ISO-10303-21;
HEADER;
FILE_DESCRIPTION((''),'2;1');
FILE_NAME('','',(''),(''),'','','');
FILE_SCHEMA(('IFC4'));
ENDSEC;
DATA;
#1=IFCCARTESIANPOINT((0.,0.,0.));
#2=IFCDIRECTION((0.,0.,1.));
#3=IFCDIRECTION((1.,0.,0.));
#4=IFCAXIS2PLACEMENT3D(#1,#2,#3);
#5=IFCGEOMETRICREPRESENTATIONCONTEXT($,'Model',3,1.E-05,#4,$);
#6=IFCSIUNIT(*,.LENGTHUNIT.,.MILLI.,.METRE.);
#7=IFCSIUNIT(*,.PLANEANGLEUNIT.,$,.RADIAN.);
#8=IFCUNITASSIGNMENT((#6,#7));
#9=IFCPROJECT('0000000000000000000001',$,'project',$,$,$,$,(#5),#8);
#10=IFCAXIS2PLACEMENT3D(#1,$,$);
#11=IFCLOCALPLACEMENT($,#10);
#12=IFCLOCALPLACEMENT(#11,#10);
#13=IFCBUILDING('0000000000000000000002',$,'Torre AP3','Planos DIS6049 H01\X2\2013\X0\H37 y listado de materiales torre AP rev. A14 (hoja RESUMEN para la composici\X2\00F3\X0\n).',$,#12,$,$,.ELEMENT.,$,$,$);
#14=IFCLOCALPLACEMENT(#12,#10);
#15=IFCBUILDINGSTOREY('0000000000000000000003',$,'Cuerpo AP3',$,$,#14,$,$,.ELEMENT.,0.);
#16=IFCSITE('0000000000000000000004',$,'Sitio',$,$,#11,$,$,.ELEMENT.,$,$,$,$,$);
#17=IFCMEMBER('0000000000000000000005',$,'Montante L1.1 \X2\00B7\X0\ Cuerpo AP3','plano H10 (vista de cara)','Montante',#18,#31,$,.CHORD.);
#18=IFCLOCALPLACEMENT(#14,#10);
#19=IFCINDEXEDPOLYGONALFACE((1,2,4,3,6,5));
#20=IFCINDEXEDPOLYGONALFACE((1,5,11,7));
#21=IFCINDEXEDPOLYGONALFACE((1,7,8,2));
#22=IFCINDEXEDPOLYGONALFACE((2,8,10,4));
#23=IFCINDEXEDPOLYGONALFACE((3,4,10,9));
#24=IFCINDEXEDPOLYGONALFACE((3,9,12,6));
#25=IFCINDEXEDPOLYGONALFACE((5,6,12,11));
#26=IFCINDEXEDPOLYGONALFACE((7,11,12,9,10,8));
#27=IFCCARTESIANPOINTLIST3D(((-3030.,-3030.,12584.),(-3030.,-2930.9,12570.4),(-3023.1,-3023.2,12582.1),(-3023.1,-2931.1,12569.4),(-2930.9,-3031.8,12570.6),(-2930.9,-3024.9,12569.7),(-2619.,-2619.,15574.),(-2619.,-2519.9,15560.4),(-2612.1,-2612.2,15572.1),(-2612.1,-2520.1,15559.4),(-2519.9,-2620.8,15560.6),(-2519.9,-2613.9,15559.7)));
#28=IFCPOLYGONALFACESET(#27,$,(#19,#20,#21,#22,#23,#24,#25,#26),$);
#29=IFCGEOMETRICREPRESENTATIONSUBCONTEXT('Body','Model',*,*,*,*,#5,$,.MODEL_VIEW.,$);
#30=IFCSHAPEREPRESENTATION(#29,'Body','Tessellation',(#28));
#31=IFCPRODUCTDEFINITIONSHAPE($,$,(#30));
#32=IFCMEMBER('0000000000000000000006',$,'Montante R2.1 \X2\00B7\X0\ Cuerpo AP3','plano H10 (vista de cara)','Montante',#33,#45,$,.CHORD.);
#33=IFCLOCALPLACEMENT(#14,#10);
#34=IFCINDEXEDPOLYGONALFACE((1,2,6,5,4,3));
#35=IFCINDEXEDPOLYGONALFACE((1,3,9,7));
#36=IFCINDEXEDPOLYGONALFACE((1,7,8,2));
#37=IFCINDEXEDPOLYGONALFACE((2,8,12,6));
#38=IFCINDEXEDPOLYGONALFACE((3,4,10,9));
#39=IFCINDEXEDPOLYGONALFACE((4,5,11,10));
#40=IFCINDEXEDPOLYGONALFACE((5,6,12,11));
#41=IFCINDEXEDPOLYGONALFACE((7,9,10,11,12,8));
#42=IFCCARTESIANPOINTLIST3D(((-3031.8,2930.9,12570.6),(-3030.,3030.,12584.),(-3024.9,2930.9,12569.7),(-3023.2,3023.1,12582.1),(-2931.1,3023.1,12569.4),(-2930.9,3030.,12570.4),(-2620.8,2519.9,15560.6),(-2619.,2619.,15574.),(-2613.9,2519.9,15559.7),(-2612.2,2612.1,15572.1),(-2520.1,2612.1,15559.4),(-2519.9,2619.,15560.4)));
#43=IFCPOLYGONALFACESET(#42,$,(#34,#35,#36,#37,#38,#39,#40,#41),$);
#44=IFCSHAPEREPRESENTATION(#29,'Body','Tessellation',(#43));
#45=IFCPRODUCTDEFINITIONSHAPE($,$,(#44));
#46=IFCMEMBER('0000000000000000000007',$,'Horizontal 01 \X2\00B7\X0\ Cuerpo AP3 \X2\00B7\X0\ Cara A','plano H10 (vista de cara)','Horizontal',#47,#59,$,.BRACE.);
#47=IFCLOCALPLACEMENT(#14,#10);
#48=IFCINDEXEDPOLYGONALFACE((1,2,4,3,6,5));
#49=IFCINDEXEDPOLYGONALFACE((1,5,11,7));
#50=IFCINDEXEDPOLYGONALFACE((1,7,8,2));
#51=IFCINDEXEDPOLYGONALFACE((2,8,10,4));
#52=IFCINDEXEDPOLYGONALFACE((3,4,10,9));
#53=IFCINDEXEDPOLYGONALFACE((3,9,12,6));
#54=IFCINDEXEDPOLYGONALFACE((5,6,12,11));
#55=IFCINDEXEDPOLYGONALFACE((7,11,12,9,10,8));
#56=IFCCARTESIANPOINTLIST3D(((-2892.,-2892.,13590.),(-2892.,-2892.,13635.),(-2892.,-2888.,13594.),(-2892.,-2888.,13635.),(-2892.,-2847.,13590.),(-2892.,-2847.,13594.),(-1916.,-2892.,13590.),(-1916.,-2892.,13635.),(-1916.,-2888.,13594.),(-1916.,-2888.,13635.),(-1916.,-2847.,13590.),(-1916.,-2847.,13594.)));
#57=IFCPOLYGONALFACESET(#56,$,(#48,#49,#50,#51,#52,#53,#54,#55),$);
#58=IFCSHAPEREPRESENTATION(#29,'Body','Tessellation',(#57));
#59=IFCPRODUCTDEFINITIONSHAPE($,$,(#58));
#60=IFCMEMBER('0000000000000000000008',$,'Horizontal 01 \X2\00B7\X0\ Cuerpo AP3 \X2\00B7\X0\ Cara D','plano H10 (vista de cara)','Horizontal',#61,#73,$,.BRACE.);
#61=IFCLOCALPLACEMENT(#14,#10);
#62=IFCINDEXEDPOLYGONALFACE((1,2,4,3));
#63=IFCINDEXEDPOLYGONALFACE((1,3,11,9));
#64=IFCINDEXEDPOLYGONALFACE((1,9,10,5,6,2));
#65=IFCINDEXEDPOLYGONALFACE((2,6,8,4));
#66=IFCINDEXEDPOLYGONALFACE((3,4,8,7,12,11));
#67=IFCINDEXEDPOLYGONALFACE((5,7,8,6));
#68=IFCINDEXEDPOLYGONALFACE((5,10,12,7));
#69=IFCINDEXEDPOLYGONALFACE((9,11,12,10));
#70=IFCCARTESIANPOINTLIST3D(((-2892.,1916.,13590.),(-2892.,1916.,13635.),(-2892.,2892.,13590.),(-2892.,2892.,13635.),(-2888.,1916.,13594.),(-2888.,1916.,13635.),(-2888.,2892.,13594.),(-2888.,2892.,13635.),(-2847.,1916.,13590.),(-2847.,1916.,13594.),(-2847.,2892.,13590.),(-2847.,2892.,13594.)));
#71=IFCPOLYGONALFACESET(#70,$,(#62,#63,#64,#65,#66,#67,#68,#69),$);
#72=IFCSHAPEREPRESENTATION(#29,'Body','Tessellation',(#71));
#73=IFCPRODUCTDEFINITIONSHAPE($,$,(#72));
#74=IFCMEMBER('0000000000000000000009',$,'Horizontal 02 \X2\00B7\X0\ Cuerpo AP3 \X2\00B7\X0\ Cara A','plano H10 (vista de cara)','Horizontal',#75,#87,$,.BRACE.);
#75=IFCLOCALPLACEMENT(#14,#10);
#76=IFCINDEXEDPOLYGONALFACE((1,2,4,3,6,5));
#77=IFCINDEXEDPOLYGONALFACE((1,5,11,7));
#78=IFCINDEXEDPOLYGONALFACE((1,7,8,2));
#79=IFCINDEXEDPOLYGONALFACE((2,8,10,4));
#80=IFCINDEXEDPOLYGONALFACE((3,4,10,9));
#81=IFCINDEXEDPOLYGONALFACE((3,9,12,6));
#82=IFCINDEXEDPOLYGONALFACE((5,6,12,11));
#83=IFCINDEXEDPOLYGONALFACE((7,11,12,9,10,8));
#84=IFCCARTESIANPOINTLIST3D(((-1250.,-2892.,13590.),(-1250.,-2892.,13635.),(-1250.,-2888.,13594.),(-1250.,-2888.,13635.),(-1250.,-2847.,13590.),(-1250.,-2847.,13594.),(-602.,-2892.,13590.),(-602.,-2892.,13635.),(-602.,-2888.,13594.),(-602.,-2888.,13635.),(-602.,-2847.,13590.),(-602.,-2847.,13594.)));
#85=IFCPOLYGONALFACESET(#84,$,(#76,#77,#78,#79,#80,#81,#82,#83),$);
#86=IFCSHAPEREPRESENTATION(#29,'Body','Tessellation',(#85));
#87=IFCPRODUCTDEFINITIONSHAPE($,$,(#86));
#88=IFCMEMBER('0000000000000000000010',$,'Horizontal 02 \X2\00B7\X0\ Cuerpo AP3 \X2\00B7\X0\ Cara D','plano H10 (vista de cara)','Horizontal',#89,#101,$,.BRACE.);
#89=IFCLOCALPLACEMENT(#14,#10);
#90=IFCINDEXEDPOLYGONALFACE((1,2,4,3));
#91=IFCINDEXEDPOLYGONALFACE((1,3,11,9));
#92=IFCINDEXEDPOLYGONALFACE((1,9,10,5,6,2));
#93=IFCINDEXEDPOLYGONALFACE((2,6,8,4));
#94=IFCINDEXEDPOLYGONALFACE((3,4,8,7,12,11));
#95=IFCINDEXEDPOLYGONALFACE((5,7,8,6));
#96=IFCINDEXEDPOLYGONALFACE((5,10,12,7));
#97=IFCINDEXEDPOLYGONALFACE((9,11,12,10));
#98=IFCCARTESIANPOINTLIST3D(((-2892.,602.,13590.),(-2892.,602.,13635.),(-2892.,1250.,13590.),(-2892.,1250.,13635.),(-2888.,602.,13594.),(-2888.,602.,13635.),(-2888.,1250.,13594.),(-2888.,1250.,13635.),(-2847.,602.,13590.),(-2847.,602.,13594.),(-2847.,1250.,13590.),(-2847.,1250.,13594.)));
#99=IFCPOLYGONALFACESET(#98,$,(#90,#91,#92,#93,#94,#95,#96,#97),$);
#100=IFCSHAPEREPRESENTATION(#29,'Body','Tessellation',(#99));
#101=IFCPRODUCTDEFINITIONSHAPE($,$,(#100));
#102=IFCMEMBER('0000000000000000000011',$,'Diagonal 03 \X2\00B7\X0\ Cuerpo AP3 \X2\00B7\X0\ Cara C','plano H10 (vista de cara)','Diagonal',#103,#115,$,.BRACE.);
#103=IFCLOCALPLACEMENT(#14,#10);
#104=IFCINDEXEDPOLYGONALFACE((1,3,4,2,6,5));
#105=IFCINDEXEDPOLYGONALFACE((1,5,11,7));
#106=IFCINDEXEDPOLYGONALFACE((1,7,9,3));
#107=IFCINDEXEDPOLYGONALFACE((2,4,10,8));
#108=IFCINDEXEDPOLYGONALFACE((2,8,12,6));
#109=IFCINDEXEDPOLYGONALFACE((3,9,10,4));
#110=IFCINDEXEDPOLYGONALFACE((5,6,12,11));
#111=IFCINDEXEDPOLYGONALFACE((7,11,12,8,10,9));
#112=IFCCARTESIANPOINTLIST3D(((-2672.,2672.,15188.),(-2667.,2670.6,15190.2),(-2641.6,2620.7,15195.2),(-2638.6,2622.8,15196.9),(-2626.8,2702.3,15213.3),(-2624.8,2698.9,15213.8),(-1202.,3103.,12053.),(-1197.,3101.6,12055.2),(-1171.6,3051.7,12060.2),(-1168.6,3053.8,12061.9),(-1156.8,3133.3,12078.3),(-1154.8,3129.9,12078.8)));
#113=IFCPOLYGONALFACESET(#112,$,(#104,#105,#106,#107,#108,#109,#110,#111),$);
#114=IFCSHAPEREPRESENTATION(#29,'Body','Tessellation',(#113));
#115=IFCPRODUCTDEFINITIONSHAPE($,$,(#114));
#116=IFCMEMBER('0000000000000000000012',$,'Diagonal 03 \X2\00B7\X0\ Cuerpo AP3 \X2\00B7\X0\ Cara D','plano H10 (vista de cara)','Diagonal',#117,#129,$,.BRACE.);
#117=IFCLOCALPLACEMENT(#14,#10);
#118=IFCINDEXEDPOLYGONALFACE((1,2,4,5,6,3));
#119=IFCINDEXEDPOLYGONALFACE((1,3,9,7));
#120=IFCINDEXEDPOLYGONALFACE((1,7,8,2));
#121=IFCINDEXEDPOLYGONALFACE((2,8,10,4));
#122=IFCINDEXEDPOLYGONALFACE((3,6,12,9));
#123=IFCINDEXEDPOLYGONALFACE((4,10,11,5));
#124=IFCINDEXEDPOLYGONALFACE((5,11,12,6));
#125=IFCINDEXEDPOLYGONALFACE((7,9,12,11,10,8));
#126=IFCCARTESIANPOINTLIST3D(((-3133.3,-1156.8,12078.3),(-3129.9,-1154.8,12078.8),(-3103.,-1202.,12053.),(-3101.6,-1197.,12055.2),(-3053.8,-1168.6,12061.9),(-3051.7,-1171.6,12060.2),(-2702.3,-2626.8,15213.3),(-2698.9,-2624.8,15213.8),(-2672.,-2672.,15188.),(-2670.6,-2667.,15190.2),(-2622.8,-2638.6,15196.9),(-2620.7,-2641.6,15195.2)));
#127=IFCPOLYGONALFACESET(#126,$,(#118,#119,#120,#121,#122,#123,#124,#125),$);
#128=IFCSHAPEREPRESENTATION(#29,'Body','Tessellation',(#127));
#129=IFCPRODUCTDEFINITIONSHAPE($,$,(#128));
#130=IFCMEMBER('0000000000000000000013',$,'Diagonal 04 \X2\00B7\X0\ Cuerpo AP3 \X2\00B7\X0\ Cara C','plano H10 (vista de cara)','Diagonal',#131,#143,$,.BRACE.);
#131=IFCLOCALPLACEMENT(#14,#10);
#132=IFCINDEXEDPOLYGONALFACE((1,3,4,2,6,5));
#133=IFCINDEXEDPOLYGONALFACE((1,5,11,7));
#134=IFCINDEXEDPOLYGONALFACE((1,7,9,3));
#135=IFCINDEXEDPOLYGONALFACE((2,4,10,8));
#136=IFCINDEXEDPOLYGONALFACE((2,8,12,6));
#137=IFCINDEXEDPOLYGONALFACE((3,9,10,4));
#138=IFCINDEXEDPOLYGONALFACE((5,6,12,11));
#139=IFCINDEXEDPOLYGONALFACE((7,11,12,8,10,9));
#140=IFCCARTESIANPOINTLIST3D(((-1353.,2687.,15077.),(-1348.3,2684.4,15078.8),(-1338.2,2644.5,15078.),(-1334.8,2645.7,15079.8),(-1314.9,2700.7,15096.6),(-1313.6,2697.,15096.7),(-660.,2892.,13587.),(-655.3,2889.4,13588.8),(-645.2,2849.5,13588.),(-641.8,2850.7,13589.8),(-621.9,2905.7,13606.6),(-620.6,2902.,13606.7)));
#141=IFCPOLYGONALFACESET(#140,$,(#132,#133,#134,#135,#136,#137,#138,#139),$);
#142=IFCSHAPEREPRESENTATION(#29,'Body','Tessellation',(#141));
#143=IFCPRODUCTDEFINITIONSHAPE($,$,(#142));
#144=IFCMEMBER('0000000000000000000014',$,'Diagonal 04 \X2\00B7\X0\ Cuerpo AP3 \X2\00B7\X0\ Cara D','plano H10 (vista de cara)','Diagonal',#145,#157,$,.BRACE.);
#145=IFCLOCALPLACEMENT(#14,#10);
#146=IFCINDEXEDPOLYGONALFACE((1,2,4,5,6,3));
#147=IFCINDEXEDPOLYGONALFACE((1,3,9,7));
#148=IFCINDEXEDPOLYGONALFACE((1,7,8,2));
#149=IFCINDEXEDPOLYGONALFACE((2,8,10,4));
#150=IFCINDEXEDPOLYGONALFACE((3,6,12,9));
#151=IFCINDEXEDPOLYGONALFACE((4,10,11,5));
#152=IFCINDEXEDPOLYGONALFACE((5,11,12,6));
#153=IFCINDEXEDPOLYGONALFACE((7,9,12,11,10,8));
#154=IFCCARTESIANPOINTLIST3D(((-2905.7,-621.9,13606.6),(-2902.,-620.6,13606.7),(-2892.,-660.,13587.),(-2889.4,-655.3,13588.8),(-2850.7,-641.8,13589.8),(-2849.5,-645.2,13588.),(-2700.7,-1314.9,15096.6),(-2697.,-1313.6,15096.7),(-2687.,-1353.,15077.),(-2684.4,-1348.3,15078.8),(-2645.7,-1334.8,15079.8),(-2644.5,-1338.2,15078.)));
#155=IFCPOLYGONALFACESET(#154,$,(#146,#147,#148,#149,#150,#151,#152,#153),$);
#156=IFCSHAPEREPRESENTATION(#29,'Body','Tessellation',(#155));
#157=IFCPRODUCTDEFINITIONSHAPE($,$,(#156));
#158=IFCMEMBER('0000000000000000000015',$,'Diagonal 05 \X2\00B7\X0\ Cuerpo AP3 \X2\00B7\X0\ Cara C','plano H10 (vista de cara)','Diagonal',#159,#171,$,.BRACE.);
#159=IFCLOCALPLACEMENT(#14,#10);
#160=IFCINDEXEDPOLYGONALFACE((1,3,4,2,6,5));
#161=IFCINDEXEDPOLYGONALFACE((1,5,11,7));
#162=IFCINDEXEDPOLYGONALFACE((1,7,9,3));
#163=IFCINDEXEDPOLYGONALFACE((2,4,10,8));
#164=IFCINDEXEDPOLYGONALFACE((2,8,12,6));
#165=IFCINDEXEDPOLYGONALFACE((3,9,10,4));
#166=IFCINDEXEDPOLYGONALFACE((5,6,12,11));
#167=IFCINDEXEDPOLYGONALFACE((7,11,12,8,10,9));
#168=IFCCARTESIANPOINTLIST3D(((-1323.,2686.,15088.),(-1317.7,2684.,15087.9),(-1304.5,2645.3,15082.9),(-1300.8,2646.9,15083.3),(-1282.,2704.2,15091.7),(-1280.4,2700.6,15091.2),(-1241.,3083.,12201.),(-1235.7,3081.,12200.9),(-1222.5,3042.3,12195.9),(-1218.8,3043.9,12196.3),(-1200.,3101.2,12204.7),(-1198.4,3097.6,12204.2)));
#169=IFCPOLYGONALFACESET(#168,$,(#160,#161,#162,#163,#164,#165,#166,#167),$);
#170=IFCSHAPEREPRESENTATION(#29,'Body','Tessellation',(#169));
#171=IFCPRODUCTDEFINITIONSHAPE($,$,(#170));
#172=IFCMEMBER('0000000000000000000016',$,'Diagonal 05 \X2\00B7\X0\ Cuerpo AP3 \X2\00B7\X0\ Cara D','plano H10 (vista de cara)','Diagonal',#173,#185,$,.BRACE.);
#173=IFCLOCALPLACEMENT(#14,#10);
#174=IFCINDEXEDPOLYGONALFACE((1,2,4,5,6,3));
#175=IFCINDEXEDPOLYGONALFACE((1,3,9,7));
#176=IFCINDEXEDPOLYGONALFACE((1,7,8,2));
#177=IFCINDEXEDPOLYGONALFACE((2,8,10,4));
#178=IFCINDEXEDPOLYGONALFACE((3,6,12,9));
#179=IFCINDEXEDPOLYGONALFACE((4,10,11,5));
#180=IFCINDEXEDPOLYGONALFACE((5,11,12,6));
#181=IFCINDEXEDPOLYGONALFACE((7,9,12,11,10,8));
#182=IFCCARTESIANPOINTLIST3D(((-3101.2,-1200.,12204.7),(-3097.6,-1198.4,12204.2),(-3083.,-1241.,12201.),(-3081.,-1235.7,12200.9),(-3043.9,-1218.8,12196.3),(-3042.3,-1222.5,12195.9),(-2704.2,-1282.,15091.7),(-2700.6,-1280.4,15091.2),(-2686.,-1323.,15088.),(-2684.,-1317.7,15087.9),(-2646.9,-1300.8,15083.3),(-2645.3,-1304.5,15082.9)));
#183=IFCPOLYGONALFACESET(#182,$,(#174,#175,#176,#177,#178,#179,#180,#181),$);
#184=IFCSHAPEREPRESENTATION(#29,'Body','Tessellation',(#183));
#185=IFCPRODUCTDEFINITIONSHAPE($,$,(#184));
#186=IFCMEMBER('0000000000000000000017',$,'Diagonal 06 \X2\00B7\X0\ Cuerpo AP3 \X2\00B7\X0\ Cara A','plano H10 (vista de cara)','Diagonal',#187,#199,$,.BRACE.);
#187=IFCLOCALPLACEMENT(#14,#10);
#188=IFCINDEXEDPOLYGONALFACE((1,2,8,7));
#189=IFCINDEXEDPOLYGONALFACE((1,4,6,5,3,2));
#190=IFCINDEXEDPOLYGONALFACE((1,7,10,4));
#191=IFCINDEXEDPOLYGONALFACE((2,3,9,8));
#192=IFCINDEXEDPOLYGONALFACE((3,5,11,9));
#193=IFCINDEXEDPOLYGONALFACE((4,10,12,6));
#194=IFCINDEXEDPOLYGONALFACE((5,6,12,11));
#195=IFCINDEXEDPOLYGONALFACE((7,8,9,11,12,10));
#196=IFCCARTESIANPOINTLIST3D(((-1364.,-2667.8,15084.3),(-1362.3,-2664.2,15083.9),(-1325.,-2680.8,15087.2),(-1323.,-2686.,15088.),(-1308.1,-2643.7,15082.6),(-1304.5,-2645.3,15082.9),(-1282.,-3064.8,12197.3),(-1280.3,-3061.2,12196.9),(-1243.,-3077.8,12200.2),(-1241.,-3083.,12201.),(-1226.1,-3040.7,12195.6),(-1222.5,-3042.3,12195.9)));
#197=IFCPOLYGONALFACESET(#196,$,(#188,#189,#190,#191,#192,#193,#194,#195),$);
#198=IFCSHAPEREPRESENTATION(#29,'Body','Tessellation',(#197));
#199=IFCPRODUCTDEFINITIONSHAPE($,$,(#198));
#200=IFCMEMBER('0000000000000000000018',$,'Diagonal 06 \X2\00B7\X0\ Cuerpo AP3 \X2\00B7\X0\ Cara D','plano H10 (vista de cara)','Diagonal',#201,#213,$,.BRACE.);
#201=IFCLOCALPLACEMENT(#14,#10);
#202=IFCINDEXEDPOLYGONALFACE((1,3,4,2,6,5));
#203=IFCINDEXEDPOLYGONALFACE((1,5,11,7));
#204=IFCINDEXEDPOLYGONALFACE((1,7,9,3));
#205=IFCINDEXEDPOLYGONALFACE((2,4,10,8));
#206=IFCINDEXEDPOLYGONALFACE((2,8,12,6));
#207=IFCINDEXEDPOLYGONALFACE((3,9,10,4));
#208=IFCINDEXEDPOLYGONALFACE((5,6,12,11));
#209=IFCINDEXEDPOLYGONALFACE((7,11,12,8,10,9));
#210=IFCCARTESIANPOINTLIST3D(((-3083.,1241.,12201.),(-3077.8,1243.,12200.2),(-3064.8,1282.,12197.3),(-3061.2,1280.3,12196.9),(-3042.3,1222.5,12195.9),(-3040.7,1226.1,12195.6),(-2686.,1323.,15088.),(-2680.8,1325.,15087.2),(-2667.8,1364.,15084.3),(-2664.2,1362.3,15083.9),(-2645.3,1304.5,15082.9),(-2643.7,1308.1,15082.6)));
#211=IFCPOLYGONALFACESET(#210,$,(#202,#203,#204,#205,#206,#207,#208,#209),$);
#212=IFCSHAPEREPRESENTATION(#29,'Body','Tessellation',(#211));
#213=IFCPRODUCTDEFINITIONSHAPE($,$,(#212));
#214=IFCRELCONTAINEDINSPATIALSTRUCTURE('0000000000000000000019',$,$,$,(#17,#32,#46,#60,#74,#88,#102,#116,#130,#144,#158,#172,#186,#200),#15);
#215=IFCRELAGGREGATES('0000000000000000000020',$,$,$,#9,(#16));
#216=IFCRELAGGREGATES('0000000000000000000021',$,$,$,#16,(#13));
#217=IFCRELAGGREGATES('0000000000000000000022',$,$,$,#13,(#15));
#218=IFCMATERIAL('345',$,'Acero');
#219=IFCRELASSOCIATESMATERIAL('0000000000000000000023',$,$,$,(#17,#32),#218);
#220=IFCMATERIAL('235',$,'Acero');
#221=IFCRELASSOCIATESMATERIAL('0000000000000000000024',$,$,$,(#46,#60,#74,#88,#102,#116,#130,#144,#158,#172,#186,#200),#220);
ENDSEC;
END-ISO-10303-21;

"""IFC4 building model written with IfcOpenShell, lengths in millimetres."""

from ifc_helpers import new_model, si_unit, frame, frame_2d, origin, origin_with_axes, place, context, subcontext, project, spatial, l_section, extrude, material, element, save


model = new_model("IFC4")

# Units and contexts
model_context = context("Model", 3, precision=1e-05, world=origin_with_axes())
body_context = subcontext(model_context, "Body", "Model", "MODEL_VIEW")
ifc_project = project(units=[si_unit("LENGTHUNIT", "METRE", prefix="MILLI"), si_unit("PLANEANGLEUNIT", "RADIAN")], contexts=[model_context])

# Site, building, storey
site_placement = place(None, origin())
site = spatial("IfcSite", under=ifc_project, at=site_placement, Name="Sitio", CompositionType="ELEMENT")
building_placement = place(site_placement, origin())
building = spatial("IfcBuilding", under=site, at=building_placement, Name="Torre AP3", Description="Planos DIS6049 H01–H37 y listado de materiales torre AP rev. A14 (hoja RESUMEN para la composición).", CompositionType="ELEMENT")
storey_placement = place(building_placement, origin())
storey = spatial("IfcBuildingStorey", under=building, at=storey_placement, Name="Cuerpo AP3", CompositionType="ELEMENT", Elevation=0.0)

# Members
ifc_material_1 = material(Name="345", Category="Acero")
for number, where, z_axis, x_axis, name in (
    (1, (-3030.0, -3030.0, 12584.0), (0.134932, 0.134932, 0.981624), (0.990855, -0.018375, -0.133675), "Montante L1.1 · Cuerpo AP3"),
    (2, (-3030.0, 3030.0, 12584.0), (0.134932, -0.134932, 0.981624), (-0.018375, -0.990855, -0.133675), "Montante R2.1 · Cuerpo AP3"),
):
    element("IfcMember", number, at=place(storey_placement, frame(where, z_axis=z_axis, x_axis=x_axis)), inside=storey, material=ifc_material_1, Name=name, Description="plano H10 (vista de cara)", ObjectType="Montante", PredefinedType="CHORD", context=body_context, shape_type="SweptSolid", body=[
        extrude(l_section(Depth=100.0, Width=100.0, Thickness=7.0, at=frame_2d((50.0, 50.0))), None, (0.0, 0.0, 1.0), 3046.0),
    ])
ifc_material_2 = material(Name="235", Category="Acero")
for number, where, z_axis, x_axis, name in (
    (3, (-2892.0, -2892.0, 13590.0), (1.0, 0.0, 0.0), (0.0, 1.0, 0.0), "Horizontal 01 · Cuerpo AP3 · Cara A"),
    (4, (-2892.0, 2892.0, 13590.0), (0.0, -1.0, 0.0), (1.0, 0.0, 0.0), "Horizontal 01 · Cuerpo AP3 · Cara D"),
):
    element("IfcMember", number, at=place(storey_placement, frame(where, z_axis=z_axis, x_axis=x_axis)), inside=storey, material=ifc_material_2, Name=name, Description="plano H10 (vista de cara)", ObjectType="Horizontal", PredefinedType="BRACE", context=body_context, shape_type="SweptSolid", body=[
        extrude(l_section(Depth=45.0, Width=45.0, Thickness=4.0, at=frame_2d((22.5, 22.5))), None, (0.0, 0.0, 1.0), 976.0),
    ])
for number, where, z_axis, x_axis, name in (
    (5, (-1250.0, -2892.0, 13590.0), (1.0, 0.0, 0.0), (0.0, 1.0, 0.0), "Horizontal 02 · Cuerpo AP3 · Cara A"),
    (6, (-2892.0, 1250.0, 13590.0), (0.0, -1.0, 0.0), (1.0, 0.0, 0.0), "Horizontal 02 · Cuerpo AP3 · Cara D"),
):
    element("IfcMember", number, at=place(storey_placement, frame(where, z_axis=z_axis, x_axis=x_axis)), inside=storey, material=ifc_material_2, Name=name, Description="plano H10 (vista de cara)", ObjectType="Horizontal", PredefinedType="BRACE", context=body_context, shape_type="SweptSolid", body=[
        extrude(l_section(Depth=45.0, Width=45.0, Thickness=4.0, at=frame_2d((22.5, 22.5))), None, (0.0, 0.0, 1.0), 648.0),
    ])
for number, where, z_axis, x_axis, name in (
    (7, (-1202.0, 3103.0, 12053.0), (-0.421294, -0.123522, 0.898473), (0.505861, -0.854262, 0.119754), "Diagonal 03 · Cuerpo AP3 · Cara C"),
    (8, (-3103.0, -1202.0, 12053.0), (0.123522, -0.421294, 0.898473), (0.854262, 0.505861, 0.119754), "Diagonal 03 · Cuerpo AP3 · Cara D"),
):
    element("IfcMember", number, at=place(storey_placement, frame(where, z_axis=z_axis, x_axis=x_axis)), inside=storey, material=ifc_material_2, Name=name, Description="plano H10 (vista de cara)", ObjectType="Diagonal", PredefinedType="BRACE", context=body_context, shape_type="SweptSolid", body=[
        extrude(l_section(Depth=60.0, Width=60.0, Thickness=4.0, at=frame_2d((30.0, 30.0))), None, (0.0, 0.0, 1.0), 3489.3),
    ])
for number, where, z_axis, x_axis, name in (
    (9, (-660.0, 2892.0, 13587.0), (-0.418475, -0.123791, 0.899752), (0.3288, -0.944119, 0.02303), "Diagonal 04 · Cuerpo AP3 · Cara C"),
    (10, (-2892.0, -660.0, 13587.0), (0.123791, -0.418475, 0.899752), (0.944119, 0.3288, 0.02303), "Diagonal 04 · Cuerpo AP3 · Cara D"),
):
    element("IfcMember", number, at=place(storey_placement, frame(where, z_axis=z_axis, x_axis=x_axis)), inside=storey, material=ifc_material_2, Name=name, Description="plano H10 (vista de cara)", ObjectType="Diagonal", PredefinedType="BRACE", context=body_context, shape_type="SweptSolid", body=[
        extrude(l_section(Depth=45.0, Width=45.0, Thickness=4.0, at=frame_2d((22.5, 22.5))), None, (0.0, 0.0, 1.0), 1656.0),
    ])
for number, where, z_axis, x_axis, name in (
    (11, (-1241.0, 3083.0, 12201.0), (-0.028127, -0.136177, 0.990285), (0.411957, -0.904214, -0.11264), "Diagonal 05 · Cuerpo AP3 · Cara C"),
    (12, (-3083.0, -1241.0, 12201.0), (0.136177, -0.028127, 0.990285), (0.904214, 0.411957, -0.11264), "Diagonal 05 · Cuerpo AP3 · Cara D"),
    (13, (-1241.0, -3083.0, 12201.0), (-0.028127, 0.136177, 0.990285), (0.411957, 0.904214, -0.11264), "Diagonal 06 · Cuerpo AP3 · Cara A"),
    (14, (-3083.0, 1241.0, 12201.0), (0.136177, 0.028127, 0.990285), (0.904214, -0.411957, -0.11264), "Diagonal 06 · Cuerpo AP3 · Cara D"),
):
    element("IfcMember", number, at=place(storey_placement, frame(where, z_axis=z_axis, x_axis=x_axis)), inside=storey, material=ifc_material_2, Name=name, Description="plano H10 (vista de cara)", ObjectType="Diagonal", PredefinedType="BRACE", context=body_context, shape_type="SweptSolid", body=[
        extrude(l_section(Depth=45.0, Width=45.0, Thickness=4.0, at=frame_2d((22.5, 22.5))), None, (0.0, 0.0, 1.0), 2915.3),
    ])

save(model, "model.ifc")
